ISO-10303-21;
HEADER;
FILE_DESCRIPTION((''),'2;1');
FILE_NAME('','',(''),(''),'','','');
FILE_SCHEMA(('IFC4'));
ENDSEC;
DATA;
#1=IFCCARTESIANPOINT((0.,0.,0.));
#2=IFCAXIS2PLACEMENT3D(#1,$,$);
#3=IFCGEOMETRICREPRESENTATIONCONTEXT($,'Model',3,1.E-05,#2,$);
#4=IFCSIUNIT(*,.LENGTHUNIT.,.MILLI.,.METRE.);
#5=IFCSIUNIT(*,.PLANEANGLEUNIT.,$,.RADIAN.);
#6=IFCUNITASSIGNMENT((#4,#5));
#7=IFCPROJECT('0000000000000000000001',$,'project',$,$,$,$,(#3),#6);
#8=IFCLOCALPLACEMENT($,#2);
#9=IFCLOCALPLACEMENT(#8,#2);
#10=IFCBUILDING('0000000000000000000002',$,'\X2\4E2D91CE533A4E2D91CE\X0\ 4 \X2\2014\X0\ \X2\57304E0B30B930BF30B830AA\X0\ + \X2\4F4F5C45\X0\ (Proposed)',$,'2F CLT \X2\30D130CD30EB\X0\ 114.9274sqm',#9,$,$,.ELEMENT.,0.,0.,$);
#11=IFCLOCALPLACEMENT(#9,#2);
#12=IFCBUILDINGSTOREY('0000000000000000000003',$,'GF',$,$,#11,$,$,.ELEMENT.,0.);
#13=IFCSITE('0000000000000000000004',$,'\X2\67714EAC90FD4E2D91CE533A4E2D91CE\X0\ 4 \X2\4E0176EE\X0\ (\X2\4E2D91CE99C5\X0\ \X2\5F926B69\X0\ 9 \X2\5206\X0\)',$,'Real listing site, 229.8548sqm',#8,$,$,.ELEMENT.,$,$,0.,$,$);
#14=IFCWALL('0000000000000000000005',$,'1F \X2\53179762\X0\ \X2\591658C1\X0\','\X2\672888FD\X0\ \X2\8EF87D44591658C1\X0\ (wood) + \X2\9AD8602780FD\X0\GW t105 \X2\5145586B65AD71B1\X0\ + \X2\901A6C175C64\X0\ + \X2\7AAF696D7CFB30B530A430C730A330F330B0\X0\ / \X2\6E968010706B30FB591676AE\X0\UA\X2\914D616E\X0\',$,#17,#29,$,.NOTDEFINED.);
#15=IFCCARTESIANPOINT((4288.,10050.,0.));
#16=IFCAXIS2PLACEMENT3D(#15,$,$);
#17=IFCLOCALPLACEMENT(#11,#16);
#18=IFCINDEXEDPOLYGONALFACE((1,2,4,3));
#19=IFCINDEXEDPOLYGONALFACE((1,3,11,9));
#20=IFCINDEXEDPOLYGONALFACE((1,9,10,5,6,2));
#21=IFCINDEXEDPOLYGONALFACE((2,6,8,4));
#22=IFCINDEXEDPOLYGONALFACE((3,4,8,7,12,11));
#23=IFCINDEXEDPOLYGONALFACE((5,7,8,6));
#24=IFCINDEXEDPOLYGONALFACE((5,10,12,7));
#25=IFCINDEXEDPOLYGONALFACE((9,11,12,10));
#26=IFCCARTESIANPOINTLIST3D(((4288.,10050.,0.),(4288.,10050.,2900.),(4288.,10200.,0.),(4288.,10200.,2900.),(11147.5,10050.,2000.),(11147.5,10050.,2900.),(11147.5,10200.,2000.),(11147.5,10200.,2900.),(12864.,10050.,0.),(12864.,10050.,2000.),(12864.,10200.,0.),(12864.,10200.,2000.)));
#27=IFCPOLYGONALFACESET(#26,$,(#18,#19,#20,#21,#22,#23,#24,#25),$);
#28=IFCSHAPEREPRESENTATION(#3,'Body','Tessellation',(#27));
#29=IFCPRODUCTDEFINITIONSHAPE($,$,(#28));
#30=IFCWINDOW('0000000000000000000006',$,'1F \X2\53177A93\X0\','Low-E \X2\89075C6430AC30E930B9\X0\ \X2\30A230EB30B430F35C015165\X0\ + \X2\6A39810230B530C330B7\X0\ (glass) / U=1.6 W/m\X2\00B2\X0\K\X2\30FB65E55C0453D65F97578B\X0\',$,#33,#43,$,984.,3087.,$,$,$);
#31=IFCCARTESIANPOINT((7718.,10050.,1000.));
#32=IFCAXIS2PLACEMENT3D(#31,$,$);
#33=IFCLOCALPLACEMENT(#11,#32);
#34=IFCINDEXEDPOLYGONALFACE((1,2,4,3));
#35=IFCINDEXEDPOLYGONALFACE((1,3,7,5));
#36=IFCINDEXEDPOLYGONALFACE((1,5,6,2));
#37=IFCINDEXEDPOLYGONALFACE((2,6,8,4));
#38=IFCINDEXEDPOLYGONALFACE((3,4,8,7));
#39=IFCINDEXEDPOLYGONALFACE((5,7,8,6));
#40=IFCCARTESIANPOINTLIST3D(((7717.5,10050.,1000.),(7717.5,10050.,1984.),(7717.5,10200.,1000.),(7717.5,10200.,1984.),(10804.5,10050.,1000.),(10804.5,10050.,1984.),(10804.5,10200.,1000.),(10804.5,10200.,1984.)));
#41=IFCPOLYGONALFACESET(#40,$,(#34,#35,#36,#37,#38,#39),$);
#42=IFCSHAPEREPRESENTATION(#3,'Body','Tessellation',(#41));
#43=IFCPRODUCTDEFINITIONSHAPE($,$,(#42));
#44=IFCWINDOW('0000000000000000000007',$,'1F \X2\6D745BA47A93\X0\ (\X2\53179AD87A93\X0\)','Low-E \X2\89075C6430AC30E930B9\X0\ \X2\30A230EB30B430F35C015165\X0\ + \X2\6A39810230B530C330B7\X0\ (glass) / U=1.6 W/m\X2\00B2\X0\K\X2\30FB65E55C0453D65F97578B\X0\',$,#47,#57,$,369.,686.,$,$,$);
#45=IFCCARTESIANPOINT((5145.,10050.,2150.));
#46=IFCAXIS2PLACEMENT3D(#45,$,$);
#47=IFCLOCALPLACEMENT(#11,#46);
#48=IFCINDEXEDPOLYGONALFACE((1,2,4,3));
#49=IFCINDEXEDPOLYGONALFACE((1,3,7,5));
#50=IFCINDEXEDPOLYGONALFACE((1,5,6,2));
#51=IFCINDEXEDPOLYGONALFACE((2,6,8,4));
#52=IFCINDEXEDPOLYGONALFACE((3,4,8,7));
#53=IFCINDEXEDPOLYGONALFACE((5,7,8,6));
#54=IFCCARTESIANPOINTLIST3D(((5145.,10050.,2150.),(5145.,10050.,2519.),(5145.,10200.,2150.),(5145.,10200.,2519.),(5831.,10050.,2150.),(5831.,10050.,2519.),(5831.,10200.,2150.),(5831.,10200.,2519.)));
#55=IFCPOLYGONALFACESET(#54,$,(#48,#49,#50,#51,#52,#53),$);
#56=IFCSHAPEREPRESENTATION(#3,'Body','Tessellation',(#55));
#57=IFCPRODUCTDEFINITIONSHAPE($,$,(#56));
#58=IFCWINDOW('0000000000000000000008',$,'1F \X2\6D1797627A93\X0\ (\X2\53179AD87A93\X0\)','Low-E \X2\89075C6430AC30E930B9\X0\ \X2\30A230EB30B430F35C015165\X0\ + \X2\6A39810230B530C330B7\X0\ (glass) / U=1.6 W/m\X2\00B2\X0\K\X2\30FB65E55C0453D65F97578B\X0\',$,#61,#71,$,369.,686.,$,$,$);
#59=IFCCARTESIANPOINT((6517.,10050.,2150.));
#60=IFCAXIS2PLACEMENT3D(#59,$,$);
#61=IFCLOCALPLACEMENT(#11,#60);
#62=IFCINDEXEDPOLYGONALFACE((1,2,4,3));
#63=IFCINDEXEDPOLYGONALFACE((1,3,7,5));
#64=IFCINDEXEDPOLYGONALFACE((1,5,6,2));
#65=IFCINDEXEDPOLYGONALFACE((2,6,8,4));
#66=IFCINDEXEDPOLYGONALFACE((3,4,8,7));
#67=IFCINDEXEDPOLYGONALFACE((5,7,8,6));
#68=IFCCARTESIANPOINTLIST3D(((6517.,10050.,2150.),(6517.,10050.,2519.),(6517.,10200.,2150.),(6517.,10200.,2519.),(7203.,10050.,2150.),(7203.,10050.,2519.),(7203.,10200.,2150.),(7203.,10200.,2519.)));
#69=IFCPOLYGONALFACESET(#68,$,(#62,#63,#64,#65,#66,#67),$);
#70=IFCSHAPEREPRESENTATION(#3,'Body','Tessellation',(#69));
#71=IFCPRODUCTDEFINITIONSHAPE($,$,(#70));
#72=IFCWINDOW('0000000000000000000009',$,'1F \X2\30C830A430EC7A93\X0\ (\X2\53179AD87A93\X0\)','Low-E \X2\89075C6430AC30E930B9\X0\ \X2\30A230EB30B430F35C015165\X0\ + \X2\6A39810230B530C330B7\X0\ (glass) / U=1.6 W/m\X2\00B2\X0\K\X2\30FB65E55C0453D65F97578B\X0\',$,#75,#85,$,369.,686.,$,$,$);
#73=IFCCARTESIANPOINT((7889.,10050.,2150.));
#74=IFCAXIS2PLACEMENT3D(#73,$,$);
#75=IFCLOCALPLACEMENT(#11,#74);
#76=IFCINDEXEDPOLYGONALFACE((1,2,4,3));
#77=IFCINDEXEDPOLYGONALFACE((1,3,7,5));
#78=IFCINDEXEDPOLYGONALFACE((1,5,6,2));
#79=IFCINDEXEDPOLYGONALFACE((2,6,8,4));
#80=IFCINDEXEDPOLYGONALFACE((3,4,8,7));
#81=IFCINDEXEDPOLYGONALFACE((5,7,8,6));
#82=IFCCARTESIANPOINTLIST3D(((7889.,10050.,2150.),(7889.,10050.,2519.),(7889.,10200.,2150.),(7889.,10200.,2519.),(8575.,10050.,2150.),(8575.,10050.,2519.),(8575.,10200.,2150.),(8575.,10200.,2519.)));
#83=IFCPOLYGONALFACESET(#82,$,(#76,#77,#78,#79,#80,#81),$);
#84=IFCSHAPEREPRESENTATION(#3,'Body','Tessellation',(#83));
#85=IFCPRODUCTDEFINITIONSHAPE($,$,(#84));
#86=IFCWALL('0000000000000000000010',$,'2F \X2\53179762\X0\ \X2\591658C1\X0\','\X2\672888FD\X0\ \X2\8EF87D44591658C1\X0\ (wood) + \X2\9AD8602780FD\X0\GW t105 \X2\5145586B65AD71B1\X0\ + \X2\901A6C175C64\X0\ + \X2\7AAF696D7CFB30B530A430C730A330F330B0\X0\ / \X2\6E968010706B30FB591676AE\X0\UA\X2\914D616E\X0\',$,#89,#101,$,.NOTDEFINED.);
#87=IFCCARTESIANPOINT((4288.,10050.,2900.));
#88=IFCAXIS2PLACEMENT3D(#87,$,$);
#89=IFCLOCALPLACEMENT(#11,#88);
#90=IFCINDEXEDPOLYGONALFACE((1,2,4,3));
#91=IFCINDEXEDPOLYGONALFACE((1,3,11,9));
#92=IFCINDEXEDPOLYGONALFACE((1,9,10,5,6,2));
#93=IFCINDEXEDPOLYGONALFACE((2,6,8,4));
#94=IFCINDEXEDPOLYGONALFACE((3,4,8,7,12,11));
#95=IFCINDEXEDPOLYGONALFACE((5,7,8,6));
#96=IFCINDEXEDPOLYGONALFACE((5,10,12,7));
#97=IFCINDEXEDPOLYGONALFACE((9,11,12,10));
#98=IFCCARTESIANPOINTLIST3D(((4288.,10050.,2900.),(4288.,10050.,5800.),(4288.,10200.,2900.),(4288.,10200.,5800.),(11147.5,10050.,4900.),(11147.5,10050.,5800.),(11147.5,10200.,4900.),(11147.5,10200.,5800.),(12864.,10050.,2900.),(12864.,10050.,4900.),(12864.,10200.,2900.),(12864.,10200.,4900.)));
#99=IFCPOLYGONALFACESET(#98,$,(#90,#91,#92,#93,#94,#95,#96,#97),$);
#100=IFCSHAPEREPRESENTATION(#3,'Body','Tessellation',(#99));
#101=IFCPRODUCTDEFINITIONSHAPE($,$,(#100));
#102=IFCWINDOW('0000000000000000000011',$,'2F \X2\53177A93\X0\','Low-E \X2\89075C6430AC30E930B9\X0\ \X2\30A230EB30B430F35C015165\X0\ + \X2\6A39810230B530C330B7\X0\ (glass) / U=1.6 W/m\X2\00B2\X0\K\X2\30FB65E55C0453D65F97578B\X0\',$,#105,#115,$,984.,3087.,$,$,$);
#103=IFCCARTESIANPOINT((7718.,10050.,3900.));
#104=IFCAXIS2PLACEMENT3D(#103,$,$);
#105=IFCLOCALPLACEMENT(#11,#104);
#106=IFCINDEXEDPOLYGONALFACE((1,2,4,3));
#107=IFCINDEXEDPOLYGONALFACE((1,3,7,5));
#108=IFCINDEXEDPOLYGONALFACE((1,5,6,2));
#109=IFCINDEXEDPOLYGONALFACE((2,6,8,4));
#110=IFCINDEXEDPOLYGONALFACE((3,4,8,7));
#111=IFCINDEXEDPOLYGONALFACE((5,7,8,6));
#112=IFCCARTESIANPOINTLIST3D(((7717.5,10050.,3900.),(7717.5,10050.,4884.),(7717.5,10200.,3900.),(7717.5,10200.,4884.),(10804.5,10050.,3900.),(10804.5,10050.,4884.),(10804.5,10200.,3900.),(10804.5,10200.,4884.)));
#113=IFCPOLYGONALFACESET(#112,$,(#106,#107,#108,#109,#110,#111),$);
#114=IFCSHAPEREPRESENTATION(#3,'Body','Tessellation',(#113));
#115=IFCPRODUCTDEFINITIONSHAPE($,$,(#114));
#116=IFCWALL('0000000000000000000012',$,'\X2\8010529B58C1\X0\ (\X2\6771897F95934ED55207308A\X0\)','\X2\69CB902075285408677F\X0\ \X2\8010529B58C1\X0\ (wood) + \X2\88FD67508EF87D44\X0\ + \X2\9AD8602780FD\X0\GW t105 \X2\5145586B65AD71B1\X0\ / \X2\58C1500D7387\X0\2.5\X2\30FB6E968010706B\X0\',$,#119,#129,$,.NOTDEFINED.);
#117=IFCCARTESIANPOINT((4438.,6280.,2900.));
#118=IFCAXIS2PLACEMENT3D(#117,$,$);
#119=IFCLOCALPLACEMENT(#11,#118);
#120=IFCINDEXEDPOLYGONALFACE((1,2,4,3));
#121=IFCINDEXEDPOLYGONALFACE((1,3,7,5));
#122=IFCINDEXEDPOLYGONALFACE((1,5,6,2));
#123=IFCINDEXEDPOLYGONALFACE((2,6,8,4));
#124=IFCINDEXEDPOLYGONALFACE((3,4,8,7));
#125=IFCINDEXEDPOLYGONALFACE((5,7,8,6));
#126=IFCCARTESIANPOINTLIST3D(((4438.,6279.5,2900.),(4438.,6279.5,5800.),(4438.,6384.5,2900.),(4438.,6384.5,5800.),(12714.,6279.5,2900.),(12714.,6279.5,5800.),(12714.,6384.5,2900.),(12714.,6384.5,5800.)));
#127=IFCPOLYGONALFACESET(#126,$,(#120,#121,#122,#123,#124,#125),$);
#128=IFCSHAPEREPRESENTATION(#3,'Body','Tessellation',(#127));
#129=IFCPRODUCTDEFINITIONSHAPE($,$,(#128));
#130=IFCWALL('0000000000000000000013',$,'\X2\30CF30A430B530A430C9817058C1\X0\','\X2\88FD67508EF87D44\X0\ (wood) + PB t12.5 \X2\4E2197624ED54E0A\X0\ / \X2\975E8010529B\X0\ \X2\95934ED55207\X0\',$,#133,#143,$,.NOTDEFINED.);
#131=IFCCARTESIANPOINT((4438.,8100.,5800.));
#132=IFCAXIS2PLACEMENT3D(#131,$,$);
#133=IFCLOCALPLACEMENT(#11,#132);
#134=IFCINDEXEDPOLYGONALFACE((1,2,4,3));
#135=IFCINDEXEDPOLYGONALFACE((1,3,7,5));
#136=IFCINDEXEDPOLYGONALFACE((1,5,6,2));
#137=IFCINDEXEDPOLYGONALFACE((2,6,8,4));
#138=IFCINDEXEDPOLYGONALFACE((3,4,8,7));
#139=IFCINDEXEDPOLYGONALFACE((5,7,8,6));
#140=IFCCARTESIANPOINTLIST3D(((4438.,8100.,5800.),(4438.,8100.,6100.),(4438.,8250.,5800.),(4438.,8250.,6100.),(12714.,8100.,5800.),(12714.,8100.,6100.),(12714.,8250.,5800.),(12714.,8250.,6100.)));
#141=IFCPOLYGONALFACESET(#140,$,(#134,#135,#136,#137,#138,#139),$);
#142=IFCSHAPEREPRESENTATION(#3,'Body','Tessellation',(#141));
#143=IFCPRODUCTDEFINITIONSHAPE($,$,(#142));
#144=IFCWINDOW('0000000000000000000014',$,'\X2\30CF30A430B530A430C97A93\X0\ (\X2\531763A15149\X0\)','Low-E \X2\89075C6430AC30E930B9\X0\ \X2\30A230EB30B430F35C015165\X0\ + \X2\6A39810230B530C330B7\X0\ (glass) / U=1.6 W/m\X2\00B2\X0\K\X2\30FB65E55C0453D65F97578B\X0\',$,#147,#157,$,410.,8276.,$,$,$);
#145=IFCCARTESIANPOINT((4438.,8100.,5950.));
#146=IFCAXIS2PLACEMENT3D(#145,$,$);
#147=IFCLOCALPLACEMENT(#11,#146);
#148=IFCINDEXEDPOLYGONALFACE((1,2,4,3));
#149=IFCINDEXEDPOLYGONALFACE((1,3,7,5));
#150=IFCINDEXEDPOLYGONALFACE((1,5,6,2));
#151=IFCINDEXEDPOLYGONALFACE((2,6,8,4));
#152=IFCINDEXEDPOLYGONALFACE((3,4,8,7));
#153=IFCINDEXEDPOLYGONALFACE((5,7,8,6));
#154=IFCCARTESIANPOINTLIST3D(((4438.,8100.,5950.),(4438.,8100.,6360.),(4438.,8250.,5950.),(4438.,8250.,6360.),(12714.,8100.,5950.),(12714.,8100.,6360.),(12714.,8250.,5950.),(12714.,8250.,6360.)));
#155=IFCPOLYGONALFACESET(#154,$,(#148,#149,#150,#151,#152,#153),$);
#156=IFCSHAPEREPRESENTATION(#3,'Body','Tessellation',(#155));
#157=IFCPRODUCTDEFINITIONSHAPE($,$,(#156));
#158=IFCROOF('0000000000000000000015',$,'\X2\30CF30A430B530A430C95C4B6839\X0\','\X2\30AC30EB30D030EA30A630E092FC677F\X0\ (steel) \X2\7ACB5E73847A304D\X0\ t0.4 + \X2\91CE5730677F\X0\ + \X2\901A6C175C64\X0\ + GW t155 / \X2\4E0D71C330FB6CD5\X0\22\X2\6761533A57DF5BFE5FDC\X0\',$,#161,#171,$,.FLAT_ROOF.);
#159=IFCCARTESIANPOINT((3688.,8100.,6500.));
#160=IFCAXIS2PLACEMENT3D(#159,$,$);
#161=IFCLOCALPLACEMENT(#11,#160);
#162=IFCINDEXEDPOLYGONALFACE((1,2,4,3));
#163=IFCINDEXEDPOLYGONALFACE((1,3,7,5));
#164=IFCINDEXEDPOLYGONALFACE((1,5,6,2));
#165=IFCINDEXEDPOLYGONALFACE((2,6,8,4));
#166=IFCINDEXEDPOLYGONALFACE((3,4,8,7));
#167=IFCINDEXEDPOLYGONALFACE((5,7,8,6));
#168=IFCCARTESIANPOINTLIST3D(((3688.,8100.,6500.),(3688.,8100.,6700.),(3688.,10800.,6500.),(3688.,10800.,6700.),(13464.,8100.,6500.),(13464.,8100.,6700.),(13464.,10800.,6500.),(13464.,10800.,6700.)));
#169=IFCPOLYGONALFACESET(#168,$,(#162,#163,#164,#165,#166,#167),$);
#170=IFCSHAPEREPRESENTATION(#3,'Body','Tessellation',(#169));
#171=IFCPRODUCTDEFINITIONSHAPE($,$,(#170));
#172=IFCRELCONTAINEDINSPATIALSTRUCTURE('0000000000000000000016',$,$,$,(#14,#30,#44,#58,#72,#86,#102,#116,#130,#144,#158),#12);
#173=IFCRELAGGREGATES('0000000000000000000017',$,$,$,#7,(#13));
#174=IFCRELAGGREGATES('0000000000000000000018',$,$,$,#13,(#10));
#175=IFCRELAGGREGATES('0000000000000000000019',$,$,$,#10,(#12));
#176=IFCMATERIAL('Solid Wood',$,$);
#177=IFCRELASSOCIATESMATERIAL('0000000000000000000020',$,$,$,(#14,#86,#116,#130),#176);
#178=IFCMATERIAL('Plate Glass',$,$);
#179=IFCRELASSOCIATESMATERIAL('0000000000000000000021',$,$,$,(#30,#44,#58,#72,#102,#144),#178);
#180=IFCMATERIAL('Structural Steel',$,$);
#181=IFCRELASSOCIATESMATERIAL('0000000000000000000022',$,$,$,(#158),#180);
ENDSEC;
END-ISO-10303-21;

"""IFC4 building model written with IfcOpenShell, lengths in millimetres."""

from ifc_helpers import new_model, si_unit, frame, frame_2d, origin, place, context, project, spatial, rectangle, extrude, material, element, fill, save


model = new_model("IFC4")

# Units and contexts
model_context = context("Model", 3, precision=1e-05, world=origin())
ifc_project = project(units=[si_unit("LENGTHUNIT", "METRE", prefix="MILLI"), si_unit("PLANEANGLEUNIT", "RADIAN")], contexts=[model_context])

# Site, building, storey
site_placement = place(None, origin())
site = spatial("IfcSite", under=ifc_project, at=site_placement, Name="東京都中野区中野 4 丁目 (中野駅 徒歩 9 分)", ObjectType="Real listing site, 229.8548sqm", CompositionType="ELEMENT", RefElevation=0.0)
building_placement = place(site_placement, origin())
building = spatial("IfcBuilding", under=site, at=building_placement, Name="中野区中野 4 — 地下スタジオ + 住居 (Proposed)", ObjectType="2F CLT パネル 114.9274sqm", CompositionType="ELEMENT", ElevationOfRefHeight=0.0, ElevationOfTerrain=0.0)
storey_placement = place(building_placement, origin())
storey = spatial("IfcBuildingStorey", under=building, at=storey_placement, Name="GF", CompositionType="ELEMENT", Elevation=0.0)

# Wall, openings, windows
ifc_material_1 = material(Name="Solid Wood")
wall_1_placement = place(storey_placement, frame((4288.0, 10050.0, 0.0)))
wall_1 = element("IfcWall", 1, at=wall_1_placement, inside=storey, material=ifc_material_1, Name="1F 北面 外壁", Description="木製 軸組外壁 (wood) + 高性能GW t105 充填断熱 + 通気層 + 窯業系サイディング / 準耐火・外皮UA配慮", PredefinedType="NOTDEFINED", context=model_context, shape_type="SweptSolid", body=[
    extrude(rectangle(XDim=8576.0, YDim=150.0, at=frame_2d((4288.0, 75.0))), frame((4288.0, 10050.0, 0.0)), (0.0, 0.0, 1.0), 2900.0),
])
opening_1_placement = place(storey_placement, frame((7718.0, 10050.0, 1000.0)))
opening_1 = element("IfcOpeningElement", 2, at=opening_1_placement, cuts=wall_1, PredefinedType="NOTDEFINED", context=model_context, shape_type="SweptSolid", body=[
    extrude(rectangle(XDim=3087.0, YDim=150.0, at=frame_2d((1543.0, 75.0))), frame((7718.0, 10050.0, 1000.0)), (0.0, 0.0, 1.0), 984.0),
])
opening_2_placement = place(storey_placement, frame((5145.0, 10050.0, 2150.0)))
opening_2 = element("IfcOpeningElement", 3, at=opening_2_placement, cuts=wall_1, PredefinedType="NOTDEFINED", context=model_context, shape_type="SweptSolid", body=[
    extrude(rectangle(XDim=686.0, YDim=150.0, at=frame_2d((343.0, 75.0))), frame((5145.0, 10050.0, 2150.0)), (0.0, 0.0, 1.0), 369.0),
])
opening_3_placement = place(storey_placement, frame((6517.0, 10050.0, 2150.0)))
opening_3 = element("IfcOpeningElement", 4, at=opening_3_placement, cuts=wall_1, PredefinedType="NOTDEFINED", context=model_context, shape_type="SweptSolid", body=[
    extrude(rectangle(XDim=686.0, YDim=150.0, at=frame_2d((343.0, 75.0))), frame((6517.0, 10050.0, 2150.0)), (0.0, 0.0, 1.0), 369.0),
])
opening_4_placement = place(storey_placement, frame((7889.0, 10050.0, 2150.0)))
opening_4 = element("IfcOpeningElement", 5, at=opening_4_placement, cuts=wall_1, PredefinedType="NOTDEFINED", context=model_context, shape_type="SweptSolid", body=[
    extrude(rectangle(XDim=686.0, YDim=150.0, at=frame_2d((343.0, 75.0))), frame((7889.0, 10050.0, 2150.0)), (0.0, 0.0, 1.0), 369.0),
])
ifc_material_2 = material(Name="Plate Glass")
window_1_placement = place(storey_placement, frame((7718.0, 10050.0, 1000.0)))
window_1 = element("IfcWindow", 6, at=window_1_placement, inside=storey, material=ifc_material_2, Name="1F 北窓", Description="Low-E 複層ガラス アルゴン封入 + 樹脂サッシ (glass) / U=1.6 W/m²K・日射取得型", OverallHeight=984.0, OverallWidth=3087.0, context=model_context, shape_type="SweptSolid", body=[
    extrude(rectangle(XDim=3087.0, YDim=150.0, at=frame_2d((1543.0, 75.0))), frame((7718.0, 10050.0, 1000.0)), (0.0, 0.0, 1.0), 984.0),
])
fill(opening_1, window_1)
window_2_placement = place(storey_placement, frame((5145.0, 10050.0, 2150.0)))
window_2 = element("IfcWindow", 7, at=window_2_placement, inside=storey, material=ifc_material_2, Name="1F 浴室窓 (北高窓)", Description="Low-E 複層ガラス アルゴン封入 + 樹脂サッシ (glass) / U=1.6 W/m²K・日射取得型", OverallHeight=369.0, OverallWidth=686.0, context=model_context, shape_type="SweptSolid", body=[
    extrude(rectangle(XDim=686.0, YDim=150.0, at=frame_2d((343.0, 75.0))), frame((5145.0, 10050.0, 2150.0)), (0.0, 0.0, 1.0), 369.0),
])
fill(opening_2, window_2)
window_3_placement = place(storey_placement, frame((6517.0, 10050.0, 2150.0)))
window_3 = element("IfcWindow", 8, at=window_3_placement, inside=storey, material=ifc_material_2, Name="1F 洗面窓 (北高窓)", Description="Low-E 複層ガラス アルゴン封入 + 樹脂サッシ (glass) / U=1.6 W/m²K・日射取得型", OverallHeight=369.0, OverallWidth=686.0, context=model_context, shape_type="SweptSolid", body=[
    extrude(rectangle(XDim=686.0, YDim=150.0, at=frame_2d((343.0, 75.0))), frame((6517.0, 10050.0, 2150.0)), (0.0, 0.0, 1.0), 369.0),
])
fill(opening_3, window_3)
window_4_placement = place(storey_placement, frame((7889.0, 10050.0, 2150.0)))
window_4 = element("IfcWindow", 9, at=window_4_placement, inside=storey, material=ifc_material_2, Name="1F トイレ窓 (北高窓)", Description="Low-E 複層ガラス アルゴン封入 + 樹脂サッシ (glass) / U=1.6 W/m²K・日射取得型", OverallHeight=369.0, OverallWidth=686.0, context=model_context, shape_type="SweptSolid", body=[
    extrude(rectangle(XDim=686.0, YDim=150.0, at=frame_2d((343.0, 75.0))), frame((7889.0, 10050.0, 2150.0)), (0.0, 0.0, 1.0), 369.0),
])
fill(opening_4, window_4)

# Wall, opening, window
wall_2_placement = place(storey_placement, frame((4288.0, 10050.0, 2900.0)))
wall_2 = element("IfcWall", 10, at=wall_2_placement, inside=storey, material=ifc_material_1, Name="2F 北面 外壁", Description="木製 軸組外壁 (wood) + 高性能GW t105 充填断熱 + 通気層 + 窯業系サイディング / 準耐火・外皮UA配慮", PredefinedType="NOTDEFINED", context=model_context, shape_type="SweptSolid", body=[
    extrude(rectangle(XDim=8576.0, YDim=150.0, at=frame_2d((4288.0, 75.0))), frame((4288.0, 10050.0, 2900.0)), (0.0, 0.0, 1.0), 2900.0),
])
opening_5_placement = place(storey_placement, frame((7718.0, 10050.0, 3900.0)))
opening_5 = element("IfcOpeningElement", 11, at=opening_5_placement, cuts=wall_2, PredefinedType="NOTDEFINED", context=model_context, shape_type="SweptSolid", body=[
    extrude(rectangle(XDim=3087.0, YDim=150.0, at=frame_2d((1543.0, 75.0))), frame((7718.0, 10050.0, 3900.0)), (0.0, 0.0, 1.0), 984.0),
])
window_5_placement = place(storey_placement, frame((7718.0, 10050.0, 3900.0)))
window_5 = element("IfcWindow", 12, at=window_5_placement, inside=storey, material=ifc_material_2, Name="2F 北窓", Description="Low-E 複層ガラス アルゴン封入 + 樹脂サッシ (glass) / U=1.6 W/m²K・日射取得型", OverallHeight=984.0, OverallWidth=3087.0, context=model_context, shape_type="SweptSolid", body=[
    extrude(rectangle(XDim=3087.0, YDim=150.0, at=frame_2d((1543.0, 75.0))), frame((7718.0, 10050.0, 3900.0)), (0.0, 0.0, 1.0), 984.0),
])
fill(opening_5, window_5)

# Wall
wall_3_placement = place(storey_placement, frame((4438.0, 6280.0, 2900.0)))
element("IfcWall", 13, at=wall_3_placement, inside=storey, material=ifc_material_1, Name="耐力壁 (東西間仕切り)", Description="構造用合板 耐力壁 (wood) + 製材軸組 + 高性能GW t105 充填断熱 / 壁倍率2.5・準耐火", PredefinedType="NOTDEFINED", context=model_context, shape_type="SweptSolid", body=[
    extrude(rectangle(XDim=8276.0, YDim=105.0, at=frame_2d((4138.0, 52.0))), frame((4438.0, 6280.0, 2900.0)), (0.0, 0.0, 1.0), 2900.0),
])

# Wall, opening, window
wall_4_placement = place(storey_placement, frame((4438.0, 8100.0, 5800.0)))
wall_4 = element("IfcWall", 14, at=wall_4_placement, inside=storey, material=ifc_material_1, Name="ハイサイド腰壁", Description="製材軸組 (wood) + PB t12.5 両面仕上 / 非耐力 間仕切", PredefinedType="NOTDEFINED", context=model_context, shape_type="SweptSolid", body=[
    extrude(rectangle(XDim=8276.0, YDim=150.0, at=frame_2d((4138.0, 75.0))), frame((4438.0, 8100.0, 5800.0)), (0.0, 0.0, 1.0), 700.0),
])
opening_6_placement = place(storey_placement, frame((4438.0, 8100.0, 5950.0)))
opening_6 = element("IfcOpeningElement", 15, at=opening_6_placement, cuts=wall_4, PredefinedType="NOTDEFINED", context=model_context, shape_type="SweptSolid", body=[
    extrude(rectangle(XDim=8276.0, YDim=150.0, at=frame_2d((4138.0, 75.0))), frame((4438.0, 8100.0, 5950.0)), (0.0, 0.0, 1.0), 410.0),
])
window_6_placement = place(storey_placement, frame((4438.0, 8100.0, 5950.0)))
window_6 = element("IfcWindow", 16, at=window_6_placement, inside=storey, material=ifc_material_2, Name="ハイサイド窓 (北採光)", Description="Low-E 複層ガラス アルゴン封入 + 樹脂サッシ (glass) / U=1.6 W/m²K・日射取得型", OverallHeight=410.0, OverallWidth=8276.0, context=model_context, shape_type="SweptSolid", body=[
    extrude(rectangle(XDim=8276.0, YDim=150.0, at=frame_2d((4138.0, 75.0))), frame((4438.0, 8100.0, 5950.0)), (0.0, 0.0, 1.0), 410.0),
])
fill(opening_6, window_6)

# Roof
ifc_material_3 = material(Name="Structural Steel")
roof_placement = place(storey_placement, frame((3688.0, 8100.0, 6500.0)))
element("IfcRoof", 17, at=roof_placement, inside=storey, material=ifc_material_3, Name="ハイサイド屋根", Description="ガルバリウム鋼板 (steel) 立平葺き t0.4 + 野地板 + 通気層 + GW t155 / 不燃・法22条区域対応", PredefinedType="FLAT_ROOF", context=model_context, shape_type="SweptSolid", body=[
    extrude(rectangle(XDim=9776.0, YDim=2700.0, at=frame_2d((4888.0, 1350.0))), frame((3688.0, 8100.0, 6500.0)), (0.0, 0.0, 1.0), 200.0),
])

save(model, "model.ifc")
